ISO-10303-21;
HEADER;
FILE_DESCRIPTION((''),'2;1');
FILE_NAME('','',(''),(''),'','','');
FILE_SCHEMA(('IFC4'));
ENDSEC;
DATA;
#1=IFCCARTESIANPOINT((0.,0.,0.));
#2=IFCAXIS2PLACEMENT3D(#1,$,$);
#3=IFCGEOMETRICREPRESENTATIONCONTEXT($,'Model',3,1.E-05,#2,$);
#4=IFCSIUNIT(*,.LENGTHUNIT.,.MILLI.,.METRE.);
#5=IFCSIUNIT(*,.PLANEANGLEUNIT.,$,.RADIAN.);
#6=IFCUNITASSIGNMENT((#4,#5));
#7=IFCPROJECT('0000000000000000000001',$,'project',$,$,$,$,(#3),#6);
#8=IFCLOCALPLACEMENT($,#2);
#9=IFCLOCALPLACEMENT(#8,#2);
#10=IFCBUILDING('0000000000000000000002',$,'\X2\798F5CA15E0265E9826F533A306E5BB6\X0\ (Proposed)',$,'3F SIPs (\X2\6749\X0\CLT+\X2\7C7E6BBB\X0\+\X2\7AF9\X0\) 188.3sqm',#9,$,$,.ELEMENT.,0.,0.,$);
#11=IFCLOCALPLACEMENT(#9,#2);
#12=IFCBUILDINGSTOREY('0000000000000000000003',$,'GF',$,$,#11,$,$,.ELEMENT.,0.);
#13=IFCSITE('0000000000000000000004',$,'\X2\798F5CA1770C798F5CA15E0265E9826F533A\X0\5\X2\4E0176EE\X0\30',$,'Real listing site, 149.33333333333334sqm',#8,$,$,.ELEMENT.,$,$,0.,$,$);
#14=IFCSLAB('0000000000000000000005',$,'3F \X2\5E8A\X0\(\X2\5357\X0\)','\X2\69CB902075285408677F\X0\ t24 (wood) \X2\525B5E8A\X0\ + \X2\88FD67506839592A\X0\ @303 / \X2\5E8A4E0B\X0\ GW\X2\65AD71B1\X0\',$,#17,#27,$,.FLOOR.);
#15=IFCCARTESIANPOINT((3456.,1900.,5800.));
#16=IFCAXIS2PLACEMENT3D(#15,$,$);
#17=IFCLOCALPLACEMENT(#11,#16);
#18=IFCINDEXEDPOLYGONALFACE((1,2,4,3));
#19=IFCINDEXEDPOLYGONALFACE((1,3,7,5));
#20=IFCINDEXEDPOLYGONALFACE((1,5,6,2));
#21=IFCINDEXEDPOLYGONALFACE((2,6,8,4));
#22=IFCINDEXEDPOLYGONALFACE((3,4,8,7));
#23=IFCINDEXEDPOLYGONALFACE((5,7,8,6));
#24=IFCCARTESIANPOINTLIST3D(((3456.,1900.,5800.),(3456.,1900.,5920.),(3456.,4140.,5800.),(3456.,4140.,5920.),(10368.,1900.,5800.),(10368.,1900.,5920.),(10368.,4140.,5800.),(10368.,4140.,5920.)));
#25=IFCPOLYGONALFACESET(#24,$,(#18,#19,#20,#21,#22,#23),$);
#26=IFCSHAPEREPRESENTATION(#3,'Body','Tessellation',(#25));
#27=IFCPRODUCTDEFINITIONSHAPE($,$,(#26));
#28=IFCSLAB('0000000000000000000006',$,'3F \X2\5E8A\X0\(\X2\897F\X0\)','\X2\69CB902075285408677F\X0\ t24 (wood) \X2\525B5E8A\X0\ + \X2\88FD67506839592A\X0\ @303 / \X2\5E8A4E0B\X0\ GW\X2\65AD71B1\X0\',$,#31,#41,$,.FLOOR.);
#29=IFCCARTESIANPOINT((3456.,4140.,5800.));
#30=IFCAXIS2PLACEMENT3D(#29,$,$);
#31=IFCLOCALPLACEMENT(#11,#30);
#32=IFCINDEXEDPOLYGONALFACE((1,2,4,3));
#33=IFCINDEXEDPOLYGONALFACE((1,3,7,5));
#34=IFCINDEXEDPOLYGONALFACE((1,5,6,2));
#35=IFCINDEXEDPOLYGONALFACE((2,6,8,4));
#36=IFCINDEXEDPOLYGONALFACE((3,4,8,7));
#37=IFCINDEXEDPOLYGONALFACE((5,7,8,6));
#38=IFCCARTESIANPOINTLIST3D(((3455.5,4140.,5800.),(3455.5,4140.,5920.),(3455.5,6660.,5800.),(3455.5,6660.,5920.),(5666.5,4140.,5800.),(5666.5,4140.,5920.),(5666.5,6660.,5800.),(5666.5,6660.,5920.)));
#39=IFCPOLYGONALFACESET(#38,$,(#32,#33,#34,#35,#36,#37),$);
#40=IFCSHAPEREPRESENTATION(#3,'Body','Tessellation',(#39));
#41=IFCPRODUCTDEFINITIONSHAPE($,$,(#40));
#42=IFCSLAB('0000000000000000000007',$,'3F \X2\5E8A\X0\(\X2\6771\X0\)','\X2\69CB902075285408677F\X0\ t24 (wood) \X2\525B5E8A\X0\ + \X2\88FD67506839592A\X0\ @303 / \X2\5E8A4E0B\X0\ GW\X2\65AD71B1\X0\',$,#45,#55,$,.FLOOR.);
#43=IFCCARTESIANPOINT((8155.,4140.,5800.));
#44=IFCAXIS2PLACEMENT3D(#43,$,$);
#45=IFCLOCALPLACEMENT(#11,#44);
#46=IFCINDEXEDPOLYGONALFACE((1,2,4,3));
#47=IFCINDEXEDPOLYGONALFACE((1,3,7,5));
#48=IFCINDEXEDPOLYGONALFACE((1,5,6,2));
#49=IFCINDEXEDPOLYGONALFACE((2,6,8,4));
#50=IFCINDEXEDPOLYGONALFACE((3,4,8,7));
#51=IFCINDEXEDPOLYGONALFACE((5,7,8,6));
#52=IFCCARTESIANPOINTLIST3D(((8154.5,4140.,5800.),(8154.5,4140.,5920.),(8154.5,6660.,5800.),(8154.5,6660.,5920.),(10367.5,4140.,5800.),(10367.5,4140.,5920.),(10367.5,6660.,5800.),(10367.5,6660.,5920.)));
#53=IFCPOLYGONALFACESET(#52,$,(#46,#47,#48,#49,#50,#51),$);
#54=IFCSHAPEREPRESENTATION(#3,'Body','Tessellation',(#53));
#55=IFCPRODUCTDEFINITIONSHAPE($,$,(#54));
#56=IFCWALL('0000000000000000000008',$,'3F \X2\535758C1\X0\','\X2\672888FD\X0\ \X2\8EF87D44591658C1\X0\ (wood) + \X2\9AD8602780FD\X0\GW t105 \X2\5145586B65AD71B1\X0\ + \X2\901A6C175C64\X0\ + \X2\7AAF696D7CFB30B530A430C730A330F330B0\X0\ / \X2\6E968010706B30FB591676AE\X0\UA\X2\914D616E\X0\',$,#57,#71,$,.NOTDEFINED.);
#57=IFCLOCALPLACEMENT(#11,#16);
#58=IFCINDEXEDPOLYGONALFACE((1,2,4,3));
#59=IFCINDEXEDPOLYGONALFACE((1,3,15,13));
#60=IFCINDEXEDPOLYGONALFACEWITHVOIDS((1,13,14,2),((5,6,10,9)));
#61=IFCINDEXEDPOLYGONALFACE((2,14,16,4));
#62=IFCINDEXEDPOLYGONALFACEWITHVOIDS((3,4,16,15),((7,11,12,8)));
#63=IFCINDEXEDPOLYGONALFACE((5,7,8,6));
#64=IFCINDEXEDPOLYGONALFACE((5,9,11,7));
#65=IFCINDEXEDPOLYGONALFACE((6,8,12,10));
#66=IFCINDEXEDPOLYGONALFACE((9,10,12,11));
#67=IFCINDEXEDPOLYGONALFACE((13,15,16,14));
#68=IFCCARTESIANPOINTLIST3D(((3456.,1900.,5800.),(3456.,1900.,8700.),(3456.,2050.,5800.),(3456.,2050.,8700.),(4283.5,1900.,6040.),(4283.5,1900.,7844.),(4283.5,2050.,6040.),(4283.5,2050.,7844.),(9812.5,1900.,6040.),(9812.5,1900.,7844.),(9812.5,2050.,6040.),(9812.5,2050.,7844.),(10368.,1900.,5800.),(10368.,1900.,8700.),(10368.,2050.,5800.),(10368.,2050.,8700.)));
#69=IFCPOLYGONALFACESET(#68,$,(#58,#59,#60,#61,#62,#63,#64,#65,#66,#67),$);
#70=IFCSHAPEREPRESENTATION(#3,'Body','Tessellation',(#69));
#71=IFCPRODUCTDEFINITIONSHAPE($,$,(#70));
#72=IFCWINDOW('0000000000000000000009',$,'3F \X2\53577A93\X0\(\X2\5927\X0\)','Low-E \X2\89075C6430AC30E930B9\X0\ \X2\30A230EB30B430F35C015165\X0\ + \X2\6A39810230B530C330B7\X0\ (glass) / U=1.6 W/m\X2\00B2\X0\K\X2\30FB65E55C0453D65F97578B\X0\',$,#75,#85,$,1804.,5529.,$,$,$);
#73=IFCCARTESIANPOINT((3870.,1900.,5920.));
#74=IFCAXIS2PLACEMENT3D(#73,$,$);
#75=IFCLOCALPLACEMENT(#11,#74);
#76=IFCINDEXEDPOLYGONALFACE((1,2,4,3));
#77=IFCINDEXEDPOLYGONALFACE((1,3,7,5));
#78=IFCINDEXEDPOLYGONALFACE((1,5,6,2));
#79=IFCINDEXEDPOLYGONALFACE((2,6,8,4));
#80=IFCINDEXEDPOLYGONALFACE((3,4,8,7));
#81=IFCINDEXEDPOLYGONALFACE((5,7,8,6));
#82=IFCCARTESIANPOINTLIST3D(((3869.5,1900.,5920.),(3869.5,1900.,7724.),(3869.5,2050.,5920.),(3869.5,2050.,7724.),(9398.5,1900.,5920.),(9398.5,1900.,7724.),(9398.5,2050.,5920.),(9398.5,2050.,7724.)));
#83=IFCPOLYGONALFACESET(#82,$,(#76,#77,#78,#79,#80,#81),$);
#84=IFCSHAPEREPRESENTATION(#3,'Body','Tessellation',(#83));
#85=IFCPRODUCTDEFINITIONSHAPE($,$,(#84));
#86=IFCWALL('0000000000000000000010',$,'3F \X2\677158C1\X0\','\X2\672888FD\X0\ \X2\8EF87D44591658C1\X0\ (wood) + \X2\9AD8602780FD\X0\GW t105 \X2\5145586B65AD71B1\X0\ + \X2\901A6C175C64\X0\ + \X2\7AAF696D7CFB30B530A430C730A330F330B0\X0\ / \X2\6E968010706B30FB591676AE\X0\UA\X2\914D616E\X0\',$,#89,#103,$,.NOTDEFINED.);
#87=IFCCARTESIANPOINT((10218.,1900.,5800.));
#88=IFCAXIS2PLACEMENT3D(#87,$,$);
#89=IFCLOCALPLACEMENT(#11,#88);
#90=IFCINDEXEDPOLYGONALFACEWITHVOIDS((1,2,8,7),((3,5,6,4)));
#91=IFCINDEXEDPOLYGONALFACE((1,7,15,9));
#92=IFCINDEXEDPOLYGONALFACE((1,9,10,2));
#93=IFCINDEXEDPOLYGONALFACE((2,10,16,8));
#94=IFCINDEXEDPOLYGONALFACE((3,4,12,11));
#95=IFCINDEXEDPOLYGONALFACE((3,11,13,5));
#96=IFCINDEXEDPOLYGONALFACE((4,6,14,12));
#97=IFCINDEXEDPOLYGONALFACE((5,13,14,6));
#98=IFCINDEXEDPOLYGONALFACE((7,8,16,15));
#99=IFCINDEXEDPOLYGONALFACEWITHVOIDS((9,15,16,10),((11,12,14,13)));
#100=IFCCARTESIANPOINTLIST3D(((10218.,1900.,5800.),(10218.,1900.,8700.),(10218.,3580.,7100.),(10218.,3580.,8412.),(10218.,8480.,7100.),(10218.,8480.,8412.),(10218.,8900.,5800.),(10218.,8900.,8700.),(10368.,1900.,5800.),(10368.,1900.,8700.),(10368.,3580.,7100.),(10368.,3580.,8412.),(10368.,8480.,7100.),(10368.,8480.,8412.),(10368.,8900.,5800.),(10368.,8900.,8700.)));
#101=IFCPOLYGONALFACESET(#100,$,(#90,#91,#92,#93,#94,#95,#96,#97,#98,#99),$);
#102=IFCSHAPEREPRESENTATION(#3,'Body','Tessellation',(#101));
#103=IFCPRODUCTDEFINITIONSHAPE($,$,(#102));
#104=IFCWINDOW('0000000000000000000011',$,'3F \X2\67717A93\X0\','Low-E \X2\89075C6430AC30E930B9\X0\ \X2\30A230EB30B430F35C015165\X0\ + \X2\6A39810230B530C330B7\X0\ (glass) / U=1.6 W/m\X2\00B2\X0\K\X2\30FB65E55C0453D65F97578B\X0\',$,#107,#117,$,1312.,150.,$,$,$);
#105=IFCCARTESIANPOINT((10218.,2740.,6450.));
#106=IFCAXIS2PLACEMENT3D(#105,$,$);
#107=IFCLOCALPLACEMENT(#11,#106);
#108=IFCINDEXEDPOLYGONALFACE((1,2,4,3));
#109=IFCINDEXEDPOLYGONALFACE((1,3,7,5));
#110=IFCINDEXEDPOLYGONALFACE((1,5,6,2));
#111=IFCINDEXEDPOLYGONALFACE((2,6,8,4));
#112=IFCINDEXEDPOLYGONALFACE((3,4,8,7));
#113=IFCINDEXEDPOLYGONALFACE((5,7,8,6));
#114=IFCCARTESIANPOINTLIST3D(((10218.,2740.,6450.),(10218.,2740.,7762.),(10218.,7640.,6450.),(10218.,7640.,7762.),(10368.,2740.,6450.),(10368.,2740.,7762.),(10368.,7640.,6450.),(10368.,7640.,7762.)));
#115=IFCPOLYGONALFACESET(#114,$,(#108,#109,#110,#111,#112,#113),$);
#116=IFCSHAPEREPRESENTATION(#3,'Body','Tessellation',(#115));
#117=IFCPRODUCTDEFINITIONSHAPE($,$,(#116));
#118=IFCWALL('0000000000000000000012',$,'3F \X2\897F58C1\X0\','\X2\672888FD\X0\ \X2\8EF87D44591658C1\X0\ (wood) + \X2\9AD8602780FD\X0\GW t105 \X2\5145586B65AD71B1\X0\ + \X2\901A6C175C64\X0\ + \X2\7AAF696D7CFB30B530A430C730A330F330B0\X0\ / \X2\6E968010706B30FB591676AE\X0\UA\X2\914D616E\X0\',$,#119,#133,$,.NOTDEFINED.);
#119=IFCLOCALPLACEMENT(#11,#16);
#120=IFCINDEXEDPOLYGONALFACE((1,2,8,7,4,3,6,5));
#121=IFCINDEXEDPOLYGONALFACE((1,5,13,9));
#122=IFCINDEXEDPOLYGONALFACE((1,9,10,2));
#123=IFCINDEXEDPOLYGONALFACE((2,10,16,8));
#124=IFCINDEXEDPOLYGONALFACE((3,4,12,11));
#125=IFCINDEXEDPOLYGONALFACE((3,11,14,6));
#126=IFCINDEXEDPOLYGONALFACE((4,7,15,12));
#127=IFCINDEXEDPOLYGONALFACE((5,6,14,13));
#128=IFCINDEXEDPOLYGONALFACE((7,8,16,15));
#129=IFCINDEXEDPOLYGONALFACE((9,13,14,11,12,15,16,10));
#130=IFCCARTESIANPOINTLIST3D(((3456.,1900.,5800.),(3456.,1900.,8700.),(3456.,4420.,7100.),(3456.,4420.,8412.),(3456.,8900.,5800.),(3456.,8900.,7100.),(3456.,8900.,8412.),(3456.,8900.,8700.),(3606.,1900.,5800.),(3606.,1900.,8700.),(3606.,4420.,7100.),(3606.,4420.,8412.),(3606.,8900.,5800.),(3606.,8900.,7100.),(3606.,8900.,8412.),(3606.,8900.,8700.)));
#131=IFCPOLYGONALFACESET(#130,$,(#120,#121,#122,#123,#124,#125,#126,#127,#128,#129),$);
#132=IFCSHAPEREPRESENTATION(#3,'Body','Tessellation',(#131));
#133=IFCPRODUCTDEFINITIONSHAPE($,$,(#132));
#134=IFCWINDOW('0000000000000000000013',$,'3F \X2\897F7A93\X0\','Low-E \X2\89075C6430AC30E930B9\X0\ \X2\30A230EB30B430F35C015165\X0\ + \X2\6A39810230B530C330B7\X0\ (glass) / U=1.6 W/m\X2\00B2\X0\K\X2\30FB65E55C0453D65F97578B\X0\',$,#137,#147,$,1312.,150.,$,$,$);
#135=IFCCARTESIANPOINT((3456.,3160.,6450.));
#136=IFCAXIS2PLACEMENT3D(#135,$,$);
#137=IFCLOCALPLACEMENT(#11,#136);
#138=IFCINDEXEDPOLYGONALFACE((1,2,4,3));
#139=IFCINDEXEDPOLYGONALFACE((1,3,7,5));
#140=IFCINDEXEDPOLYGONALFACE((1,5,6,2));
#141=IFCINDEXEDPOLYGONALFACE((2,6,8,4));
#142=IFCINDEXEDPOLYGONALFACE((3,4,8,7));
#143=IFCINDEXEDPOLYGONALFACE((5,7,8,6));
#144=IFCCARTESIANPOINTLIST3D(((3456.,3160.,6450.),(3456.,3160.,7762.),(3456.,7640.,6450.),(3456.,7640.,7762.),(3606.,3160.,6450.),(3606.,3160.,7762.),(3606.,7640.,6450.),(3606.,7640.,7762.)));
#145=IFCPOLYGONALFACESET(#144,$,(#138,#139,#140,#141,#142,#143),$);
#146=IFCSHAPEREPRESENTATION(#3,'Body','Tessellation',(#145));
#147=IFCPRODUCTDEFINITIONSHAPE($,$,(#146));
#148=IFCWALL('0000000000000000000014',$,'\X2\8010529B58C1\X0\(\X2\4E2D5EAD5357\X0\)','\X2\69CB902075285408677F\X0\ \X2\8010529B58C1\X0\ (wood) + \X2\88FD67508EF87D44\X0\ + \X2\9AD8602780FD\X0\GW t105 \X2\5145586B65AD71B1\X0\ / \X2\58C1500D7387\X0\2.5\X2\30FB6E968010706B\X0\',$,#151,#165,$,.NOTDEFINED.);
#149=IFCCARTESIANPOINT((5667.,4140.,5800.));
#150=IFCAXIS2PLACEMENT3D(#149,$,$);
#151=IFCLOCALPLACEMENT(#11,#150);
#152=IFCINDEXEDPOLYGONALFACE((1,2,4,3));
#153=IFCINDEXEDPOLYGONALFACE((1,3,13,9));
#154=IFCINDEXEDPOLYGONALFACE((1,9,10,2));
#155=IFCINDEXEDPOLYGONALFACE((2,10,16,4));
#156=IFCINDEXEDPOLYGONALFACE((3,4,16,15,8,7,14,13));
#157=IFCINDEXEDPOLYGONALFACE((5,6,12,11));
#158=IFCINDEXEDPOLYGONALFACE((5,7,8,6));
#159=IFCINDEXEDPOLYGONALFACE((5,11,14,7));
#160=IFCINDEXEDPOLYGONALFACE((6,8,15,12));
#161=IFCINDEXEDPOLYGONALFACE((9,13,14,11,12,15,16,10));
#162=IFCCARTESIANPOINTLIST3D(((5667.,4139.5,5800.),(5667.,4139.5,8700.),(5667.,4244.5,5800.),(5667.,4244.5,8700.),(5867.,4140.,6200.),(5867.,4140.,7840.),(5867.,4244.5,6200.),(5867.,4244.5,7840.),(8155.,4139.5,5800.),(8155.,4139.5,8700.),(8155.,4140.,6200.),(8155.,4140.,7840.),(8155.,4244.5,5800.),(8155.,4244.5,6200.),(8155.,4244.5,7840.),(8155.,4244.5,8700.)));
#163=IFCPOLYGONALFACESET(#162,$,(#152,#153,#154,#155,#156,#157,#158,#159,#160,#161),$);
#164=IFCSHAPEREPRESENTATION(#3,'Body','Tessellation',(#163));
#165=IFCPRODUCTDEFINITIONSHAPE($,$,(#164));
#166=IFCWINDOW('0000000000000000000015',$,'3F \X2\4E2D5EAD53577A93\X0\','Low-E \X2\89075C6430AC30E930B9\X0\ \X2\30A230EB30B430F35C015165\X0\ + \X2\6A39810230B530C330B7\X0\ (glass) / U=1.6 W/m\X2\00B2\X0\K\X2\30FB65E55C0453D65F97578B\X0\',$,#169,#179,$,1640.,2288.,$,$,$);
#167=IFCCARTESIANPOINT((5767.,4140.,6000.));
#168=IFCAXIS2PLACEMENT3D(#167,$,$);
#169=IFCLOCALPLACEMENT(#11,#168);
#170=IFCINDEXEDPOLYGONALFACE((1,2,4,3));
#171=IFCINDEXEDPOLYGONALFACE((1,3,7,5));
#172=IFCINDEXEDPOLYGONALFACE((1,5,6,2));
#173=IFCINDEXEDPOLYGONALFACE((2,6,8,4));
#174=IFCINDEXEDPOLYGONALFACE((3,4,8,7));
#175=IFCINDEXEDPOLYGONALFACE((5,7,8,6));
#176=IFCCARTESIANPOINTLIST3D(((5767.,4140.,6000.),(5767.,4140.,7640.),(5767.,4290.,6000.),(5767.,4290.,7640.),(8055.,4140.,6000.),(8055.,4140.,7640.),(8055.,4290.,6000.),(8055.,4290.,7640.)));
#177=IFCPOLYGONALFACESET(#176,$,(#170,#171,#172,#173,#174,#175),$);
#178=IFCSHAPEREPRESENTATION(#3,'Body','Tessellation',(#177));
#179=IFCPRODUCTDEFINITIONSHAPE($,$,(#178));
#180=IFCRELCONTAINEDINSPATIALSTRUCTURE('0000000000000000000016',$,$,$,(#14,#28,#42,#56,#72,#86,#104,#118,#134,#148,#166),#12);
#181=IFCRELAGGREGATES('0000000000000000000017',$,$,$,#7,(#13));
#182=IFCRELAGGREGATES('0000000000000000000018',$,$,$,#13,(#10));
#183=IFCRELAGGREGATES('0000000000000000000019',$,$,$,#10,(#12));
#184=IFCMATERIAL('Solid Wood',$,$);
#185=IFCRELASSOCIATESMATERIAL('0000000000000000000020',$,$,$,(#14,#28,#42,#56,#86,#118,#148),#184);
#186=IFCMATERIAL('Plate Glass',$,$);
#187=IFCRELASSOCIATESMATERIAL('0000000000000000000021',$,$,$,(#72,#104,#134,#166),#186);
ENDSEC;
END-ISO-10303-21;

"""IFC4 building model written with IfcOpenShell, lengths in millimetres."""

from ifc_helpers import new_model, si_unit, frame, frame_2d, origin, place, context, project, spatial, rectangle, extrude, material, element, fill, save


model = new_model("IFC4")

# Units and contexts
model_context = context("Model", 3, precision=1e-05, world=origin())
ifc_project = project(units=[si_unit("LENGTHUNIT", "METRE", prefix="MILLI"), si_unit("PLANEANGLEUNIT", "RADIAN")], contexts=[model_context])

# Site, building, storey
site_placement = place(None, origin())
site = spatial("IfcSite", under=ifc_project, at=site_placement, Name="福岡県福岡市早良区5丁目30", ObjectType="Real listing site, 149.33333333333334sqm", CompositionType="ELEMENT", RefElevation=0.0)
building_placement = place(site_placement, origin())
building = spatial("IfcBuilding", under=site, at=building_placement, Name="福岡市早良区の家 (Proposed)", ObjectType="3F SIPs (杉CLT+籾殻+竹) 188.3sqm", CompositionType="ELEMENT", ElevationOfRefHeight=0.0, ElevationOfTerrain=0.0)
storey_placement = place(building_placement, origin())
storey = spatial("IfcBuildingStorey", under=building, at=storey_placement, Name="GF", CompositionType="ELEMENT", Elevation=0.0)

# Slabs
ifc_material_1 = material(Name="Solid Wood")
slab_1_placement = place(storey_placement, frame((3456.0, 1900.0, 5800.0)))
element("IfcSlab", 1, at=slab_1_placement, inside=storey, material=ifc_material_1, Name="3F 床(南)", Description="構造用合板 t24 (wood) 剛床 + 製材根太 @303 / 床下 GW断熱", PredefinedType="FLOOR", context=model_context, shape_type="SweptSolid", body=[
    extrude(rectangle(XDim=6912.0, YDim=2240.0, at=frame_2d((3456.0, 1120.0))), frame((3456.0, 1900.0, 5800.0)), (0.0, 0.0, 1.0), 120.0),
])
slab_2_placement = place(storey_placement, frame((3456.0, 4140.0, 5800.0)))
element("IfcSlab", 2, at=slab_2_placement, inside=storey, material=ifc_material_1, Name="3F 床(西)", Description="構造用合板 t24 (wood) 剛床 + 製材根太 @303 / 床下 GW断熱", PredefinedType="FLOOR", context=model_context, shape_type="SweptSolid", body=[
    extrude(rectangle(XDim=2211.0, YDim=2520.0, at=frame_2d((1105.0, 1260.0))), frame((3456.0, 4140.0, 5800.0)), (0.0, 0.0, 1.0), 120.0),
])
slab_3_placement = place(storey_placement, frame((8155.0, 4140.0, 5800.0)))
element("IfcSlab", 3, at=slab_3_placement, inside=storey, material=ifc_material_1, Name="3F 床(東)", Description="構造用合板 t24 (wood) 剛床 + 製材根太 @303 / 床下 GW断熱", PredefinedType="FLOOR", context=model_context, shape_type="SweptSolid", body=[
    extrude(rectangle(XDim=2213.0, YDim=2520.0, at=frame_2d((1106.0, 1260.0))), frame((8155.0, 4140.0, 5800.0)), (0.0, 0.0, 1.0), 120.0),
])

# Walls, openings, windows
wall_1_placement = place(storey_placement, frame((3456.0, 1900.0, 5800.0)))
wall_1 = element("IfcWall", 4, at=wall_1_placement, inside=storey, material=ifc_material_1, Name="3F 南壁", Description="木製 軸組外壁 (wood) + 高性能GW t105 充填断熱 + 通気層 + 窯業系サイディング / 準耐火・外皮UA配慮", PredefinedType="NOTDEFINED", context=model_context, shape_type="SweptSolid", body=[
    extrude(rectangle(XDim=6912.0, YDim=150.0, at=frame_2d((3456.0, 75.0))), frame((3456.0, 1900.0, 5800.0)), (0.0, 0.0, 1.0), 2900.0),
])
opening_1_placement = place(storey_placement, frame((3870.0, 1900.0, 5920.0)))
opening_1 = element("IfcOpeningElement", 5, at=opening_1_placement, cuts=wall_1, PredefinedType="NOTDEFINED", context=model_context, shape_type="SweptSolid", body=[
    extrude(rectangle(XDim=5529.0, YDim=150.0, at=frame_2d((2764.0, 75.0))), frame((3870.0, 1900.0, 5920.0)), (0.0, 0.0, 1.0), 1804.0),
])
ifc_material_2 = material(Name="Plate Glass")
window_1_placement = place(storey_placement, frame((3870.0, 1900.0, 5920.0)))
window_1 = element("IfcWindow", 6, at=window_1_placement, inside=storey, material=ifc_material_2, Name="3F 南窓(大)", Description="Low-E 複層ガラス アルゴン封入 + 樹脂サッシ (glass) / U=1.6 W/m²K・日射取得型", OverallHeight=1804.0, OverallWidth=5529.0, context=model_context, shape_type="SweptSolid", body=[
    extrude(rectangle(XDim=5529.0, YDim=150.0, at=frame_2d((2764.0, 75.0))), frame((3870.0, 1900.0, 5920.0)), (0.0, 0.0, 1.0), 1804.0),
])
fill(opening_1, window_1)
wall_2_placement = place(storey_placement, frame((10218.0, 1900.0, 5800.0)))
wall_2 = element("IfcWall", 7, at=wall_2_placement, inside=storey, material=ifc_material_1, Name="3F 東壁", Description="木製 軸組外壁 (wood) + 高性能GW t105 充填断熱 + 通気層 + 窯業系サイディング / 準耐火・外皮UA配慮", PredefinedType="NOTDEFINED", context=model_context, shape_type="SweptSolid", body=[
    extrude(rectangle(XDim=150.0, YDim=7000.0, at=frame_2d((75.0, 3500.0))), frame((10218.0, 1900.0, 5800.0)), (0.0, 0.0, 1.0), 2900.0),
])
opening_2_placement = place(storey_placement, frame((10218.0, 2740.0, 6450.0)))
opening_2 = element("IfcOpeningElement", 8, at=opening_2_placement, cuts=wall_2, PredefinedType="NOTDEFINED", context=model_context, shape_type="SweptSolid", body=[
    extrude(rectangle(XDim=150.0, YDim=4900.0, at=frame_2d((75.0, 2450.0))), frame((10218.0, 2740.0, 6450.0)), (0.0, 0.0, 1.0), 1312.0),
])
window_2_placement = place(storey_placement, frame((10218.0, 2740.0, 6450.0)))
window_2 = element("IfcWindow", 9, at=window_2_placement, inside=storey, material=ifc_material_2, Name="3F 東窓", Description="Low-E 複層ガラス アルゴン封入 + 樹脂サッシ (glass) / U=1.6 W/m²K・日射取得型", OverallHeight=1312.0, OverallWidth=150.0, context=model_context, shape_type="SweptSolid", body=[
    extrude(rectangle(XDim=150.0, YDim=4900.0, at=frame_2d((75.0, 2450.0))), frame((10218.0, 2740.0, 6450.0)), (0.0, 0.0, 1.0), 1312.0),
])
fill(opening_2, window_2)
wall_3_placement = place(storey_placement, frame((3456.0, 1900.0, 5800.0)))
wall_3 = element("IfcWall", 10, at=wall_3_placement, inside=storey, material=ifc_material_1, Name="3F 西壁", Description="木製 軸組外壁 (wood) + 高性能GW t105 充填断熱 + 通気層 + 窯業系サイディング / 準耐火・外皮UA配慮", PredefinedType="NOTDEFINED", context=model_context, shape_type="SweptSolid", body=[
    extrude(rectangle(XDim=150.0, YDim=7000.0, at=frame_2d((75.0, 3500.0))), frame((3456.0, 1900.0, 5800.0)), (0.0, 0.0, 1.0), 2900.0),
])
opening_3_placement = place(storey_placement, frame((3456.0, 3160.0, 6450.0)))
opening_3 = element("IfcOpeningElement", 11, at=opening_3_placement, cuts=wall_3, PredefinedType="NOTDEFINED", context=model_context, shape_type="SweptSolid", body=[
    extrude(rectangle(XDim=150.0, YDim=4480.0, at=frame_2d((75.0, 2240.0))), frame((3456.0, 3160.0, 6450.0)), (0.0, 0.0, 1.0), 1312.0),
])
window_3_placement = place(storey_placement, frame((3456.0, 3160.0, 6450.0)))
window_3 = element("IfcWindow", 12, at=window_3_placement, inside=storey, material=ifc_material_2, Name="3F 西窓", Description="Low-E 複層ガラス アルゴン封入 + 樹脂サッシ (glass) / U=1.6 W/m²K・日射取得型", OverallHeight=1312.0, OverallWidth=150.0, context=model_context, shape_type="SweptSolid", body=[
    extrude(rectangle(XDim=150.0, YDim=4480.0, at=frame_2d((75.0, 2240.0))), frame((3456.0, 3160.0, 6450.0)), (0.0, 0.0, 1.0), 1312.0),
])
fill(opening_3, window_3)
wall_4_placement = place(storey_placement, frame((5667.0, 4140.0, 5800.0)))
wall_4 = element("IfcWall", 13, at=wall_4_placement, inside=storey, material=ifc_material_1, Name="耐力壁(中庭南)", Description="構造用合板 耐力壁 (wood) + 製材軸組 + 高性能GW t105 充填断熱 / 壁倍率2.5・準耐火", PredefinedType="NOTDEFINED", context=model_context, shape_type="SweptSolid", body=[
    extrude(rectangle(XDim=2488.0, YDim=105.0, at=frame_2d((1244.0, 52.0))), frame((5667.0, 4140.0, 5800.0)), (0.0, 0.0, 1.0), 2900.0),
])
opening_4_placement = place(storey_placement, frame((5767.0, 4140.0, 6000.0)))
opening_4 = element("IfcOpeningElement", 14, at=opening_4_placement, cuts=wall_4, PredefinedType="NOTDEFINED", context=model_context, shape_type="SweptSolid", body=[
    extrude(rectangle(XDim=2288.0, YDim=150.0, at=frame_2d((1144.0, 75.0))), frame((5767.0, 4140.0, 6000.0)), (0.0, 0.0, 1.0), 1640.0),
])
window_4_placement = place(storey_placement, frame((5767.0, 4140.0, 6000.0)))
window_4 = element("IfcWindow", 15, at=window_4_placement, inside=storey, material=ifc_material_2, Name="3F 中庭南窓", Description="Low-E 複層ガラス アルゴン封入 + 樹脂サッシ (glass) / U=1.6 W/m²K・日射取得型", OverallHeight=1640.0, OverallWidth=2288.0, context=model_context, shape_type="SweptSolid", body=[
    extrude(rectangle(XDim=2288.0, YDim=150.0, at=frame_2d((1144.0, 75.0))), frame((5767.0, 4140.0, 6000.0)), (0.0, 0.0, 1.0), 1640.0),
])
fill(opening_4, window_4)

save(model, "model.ifc")
